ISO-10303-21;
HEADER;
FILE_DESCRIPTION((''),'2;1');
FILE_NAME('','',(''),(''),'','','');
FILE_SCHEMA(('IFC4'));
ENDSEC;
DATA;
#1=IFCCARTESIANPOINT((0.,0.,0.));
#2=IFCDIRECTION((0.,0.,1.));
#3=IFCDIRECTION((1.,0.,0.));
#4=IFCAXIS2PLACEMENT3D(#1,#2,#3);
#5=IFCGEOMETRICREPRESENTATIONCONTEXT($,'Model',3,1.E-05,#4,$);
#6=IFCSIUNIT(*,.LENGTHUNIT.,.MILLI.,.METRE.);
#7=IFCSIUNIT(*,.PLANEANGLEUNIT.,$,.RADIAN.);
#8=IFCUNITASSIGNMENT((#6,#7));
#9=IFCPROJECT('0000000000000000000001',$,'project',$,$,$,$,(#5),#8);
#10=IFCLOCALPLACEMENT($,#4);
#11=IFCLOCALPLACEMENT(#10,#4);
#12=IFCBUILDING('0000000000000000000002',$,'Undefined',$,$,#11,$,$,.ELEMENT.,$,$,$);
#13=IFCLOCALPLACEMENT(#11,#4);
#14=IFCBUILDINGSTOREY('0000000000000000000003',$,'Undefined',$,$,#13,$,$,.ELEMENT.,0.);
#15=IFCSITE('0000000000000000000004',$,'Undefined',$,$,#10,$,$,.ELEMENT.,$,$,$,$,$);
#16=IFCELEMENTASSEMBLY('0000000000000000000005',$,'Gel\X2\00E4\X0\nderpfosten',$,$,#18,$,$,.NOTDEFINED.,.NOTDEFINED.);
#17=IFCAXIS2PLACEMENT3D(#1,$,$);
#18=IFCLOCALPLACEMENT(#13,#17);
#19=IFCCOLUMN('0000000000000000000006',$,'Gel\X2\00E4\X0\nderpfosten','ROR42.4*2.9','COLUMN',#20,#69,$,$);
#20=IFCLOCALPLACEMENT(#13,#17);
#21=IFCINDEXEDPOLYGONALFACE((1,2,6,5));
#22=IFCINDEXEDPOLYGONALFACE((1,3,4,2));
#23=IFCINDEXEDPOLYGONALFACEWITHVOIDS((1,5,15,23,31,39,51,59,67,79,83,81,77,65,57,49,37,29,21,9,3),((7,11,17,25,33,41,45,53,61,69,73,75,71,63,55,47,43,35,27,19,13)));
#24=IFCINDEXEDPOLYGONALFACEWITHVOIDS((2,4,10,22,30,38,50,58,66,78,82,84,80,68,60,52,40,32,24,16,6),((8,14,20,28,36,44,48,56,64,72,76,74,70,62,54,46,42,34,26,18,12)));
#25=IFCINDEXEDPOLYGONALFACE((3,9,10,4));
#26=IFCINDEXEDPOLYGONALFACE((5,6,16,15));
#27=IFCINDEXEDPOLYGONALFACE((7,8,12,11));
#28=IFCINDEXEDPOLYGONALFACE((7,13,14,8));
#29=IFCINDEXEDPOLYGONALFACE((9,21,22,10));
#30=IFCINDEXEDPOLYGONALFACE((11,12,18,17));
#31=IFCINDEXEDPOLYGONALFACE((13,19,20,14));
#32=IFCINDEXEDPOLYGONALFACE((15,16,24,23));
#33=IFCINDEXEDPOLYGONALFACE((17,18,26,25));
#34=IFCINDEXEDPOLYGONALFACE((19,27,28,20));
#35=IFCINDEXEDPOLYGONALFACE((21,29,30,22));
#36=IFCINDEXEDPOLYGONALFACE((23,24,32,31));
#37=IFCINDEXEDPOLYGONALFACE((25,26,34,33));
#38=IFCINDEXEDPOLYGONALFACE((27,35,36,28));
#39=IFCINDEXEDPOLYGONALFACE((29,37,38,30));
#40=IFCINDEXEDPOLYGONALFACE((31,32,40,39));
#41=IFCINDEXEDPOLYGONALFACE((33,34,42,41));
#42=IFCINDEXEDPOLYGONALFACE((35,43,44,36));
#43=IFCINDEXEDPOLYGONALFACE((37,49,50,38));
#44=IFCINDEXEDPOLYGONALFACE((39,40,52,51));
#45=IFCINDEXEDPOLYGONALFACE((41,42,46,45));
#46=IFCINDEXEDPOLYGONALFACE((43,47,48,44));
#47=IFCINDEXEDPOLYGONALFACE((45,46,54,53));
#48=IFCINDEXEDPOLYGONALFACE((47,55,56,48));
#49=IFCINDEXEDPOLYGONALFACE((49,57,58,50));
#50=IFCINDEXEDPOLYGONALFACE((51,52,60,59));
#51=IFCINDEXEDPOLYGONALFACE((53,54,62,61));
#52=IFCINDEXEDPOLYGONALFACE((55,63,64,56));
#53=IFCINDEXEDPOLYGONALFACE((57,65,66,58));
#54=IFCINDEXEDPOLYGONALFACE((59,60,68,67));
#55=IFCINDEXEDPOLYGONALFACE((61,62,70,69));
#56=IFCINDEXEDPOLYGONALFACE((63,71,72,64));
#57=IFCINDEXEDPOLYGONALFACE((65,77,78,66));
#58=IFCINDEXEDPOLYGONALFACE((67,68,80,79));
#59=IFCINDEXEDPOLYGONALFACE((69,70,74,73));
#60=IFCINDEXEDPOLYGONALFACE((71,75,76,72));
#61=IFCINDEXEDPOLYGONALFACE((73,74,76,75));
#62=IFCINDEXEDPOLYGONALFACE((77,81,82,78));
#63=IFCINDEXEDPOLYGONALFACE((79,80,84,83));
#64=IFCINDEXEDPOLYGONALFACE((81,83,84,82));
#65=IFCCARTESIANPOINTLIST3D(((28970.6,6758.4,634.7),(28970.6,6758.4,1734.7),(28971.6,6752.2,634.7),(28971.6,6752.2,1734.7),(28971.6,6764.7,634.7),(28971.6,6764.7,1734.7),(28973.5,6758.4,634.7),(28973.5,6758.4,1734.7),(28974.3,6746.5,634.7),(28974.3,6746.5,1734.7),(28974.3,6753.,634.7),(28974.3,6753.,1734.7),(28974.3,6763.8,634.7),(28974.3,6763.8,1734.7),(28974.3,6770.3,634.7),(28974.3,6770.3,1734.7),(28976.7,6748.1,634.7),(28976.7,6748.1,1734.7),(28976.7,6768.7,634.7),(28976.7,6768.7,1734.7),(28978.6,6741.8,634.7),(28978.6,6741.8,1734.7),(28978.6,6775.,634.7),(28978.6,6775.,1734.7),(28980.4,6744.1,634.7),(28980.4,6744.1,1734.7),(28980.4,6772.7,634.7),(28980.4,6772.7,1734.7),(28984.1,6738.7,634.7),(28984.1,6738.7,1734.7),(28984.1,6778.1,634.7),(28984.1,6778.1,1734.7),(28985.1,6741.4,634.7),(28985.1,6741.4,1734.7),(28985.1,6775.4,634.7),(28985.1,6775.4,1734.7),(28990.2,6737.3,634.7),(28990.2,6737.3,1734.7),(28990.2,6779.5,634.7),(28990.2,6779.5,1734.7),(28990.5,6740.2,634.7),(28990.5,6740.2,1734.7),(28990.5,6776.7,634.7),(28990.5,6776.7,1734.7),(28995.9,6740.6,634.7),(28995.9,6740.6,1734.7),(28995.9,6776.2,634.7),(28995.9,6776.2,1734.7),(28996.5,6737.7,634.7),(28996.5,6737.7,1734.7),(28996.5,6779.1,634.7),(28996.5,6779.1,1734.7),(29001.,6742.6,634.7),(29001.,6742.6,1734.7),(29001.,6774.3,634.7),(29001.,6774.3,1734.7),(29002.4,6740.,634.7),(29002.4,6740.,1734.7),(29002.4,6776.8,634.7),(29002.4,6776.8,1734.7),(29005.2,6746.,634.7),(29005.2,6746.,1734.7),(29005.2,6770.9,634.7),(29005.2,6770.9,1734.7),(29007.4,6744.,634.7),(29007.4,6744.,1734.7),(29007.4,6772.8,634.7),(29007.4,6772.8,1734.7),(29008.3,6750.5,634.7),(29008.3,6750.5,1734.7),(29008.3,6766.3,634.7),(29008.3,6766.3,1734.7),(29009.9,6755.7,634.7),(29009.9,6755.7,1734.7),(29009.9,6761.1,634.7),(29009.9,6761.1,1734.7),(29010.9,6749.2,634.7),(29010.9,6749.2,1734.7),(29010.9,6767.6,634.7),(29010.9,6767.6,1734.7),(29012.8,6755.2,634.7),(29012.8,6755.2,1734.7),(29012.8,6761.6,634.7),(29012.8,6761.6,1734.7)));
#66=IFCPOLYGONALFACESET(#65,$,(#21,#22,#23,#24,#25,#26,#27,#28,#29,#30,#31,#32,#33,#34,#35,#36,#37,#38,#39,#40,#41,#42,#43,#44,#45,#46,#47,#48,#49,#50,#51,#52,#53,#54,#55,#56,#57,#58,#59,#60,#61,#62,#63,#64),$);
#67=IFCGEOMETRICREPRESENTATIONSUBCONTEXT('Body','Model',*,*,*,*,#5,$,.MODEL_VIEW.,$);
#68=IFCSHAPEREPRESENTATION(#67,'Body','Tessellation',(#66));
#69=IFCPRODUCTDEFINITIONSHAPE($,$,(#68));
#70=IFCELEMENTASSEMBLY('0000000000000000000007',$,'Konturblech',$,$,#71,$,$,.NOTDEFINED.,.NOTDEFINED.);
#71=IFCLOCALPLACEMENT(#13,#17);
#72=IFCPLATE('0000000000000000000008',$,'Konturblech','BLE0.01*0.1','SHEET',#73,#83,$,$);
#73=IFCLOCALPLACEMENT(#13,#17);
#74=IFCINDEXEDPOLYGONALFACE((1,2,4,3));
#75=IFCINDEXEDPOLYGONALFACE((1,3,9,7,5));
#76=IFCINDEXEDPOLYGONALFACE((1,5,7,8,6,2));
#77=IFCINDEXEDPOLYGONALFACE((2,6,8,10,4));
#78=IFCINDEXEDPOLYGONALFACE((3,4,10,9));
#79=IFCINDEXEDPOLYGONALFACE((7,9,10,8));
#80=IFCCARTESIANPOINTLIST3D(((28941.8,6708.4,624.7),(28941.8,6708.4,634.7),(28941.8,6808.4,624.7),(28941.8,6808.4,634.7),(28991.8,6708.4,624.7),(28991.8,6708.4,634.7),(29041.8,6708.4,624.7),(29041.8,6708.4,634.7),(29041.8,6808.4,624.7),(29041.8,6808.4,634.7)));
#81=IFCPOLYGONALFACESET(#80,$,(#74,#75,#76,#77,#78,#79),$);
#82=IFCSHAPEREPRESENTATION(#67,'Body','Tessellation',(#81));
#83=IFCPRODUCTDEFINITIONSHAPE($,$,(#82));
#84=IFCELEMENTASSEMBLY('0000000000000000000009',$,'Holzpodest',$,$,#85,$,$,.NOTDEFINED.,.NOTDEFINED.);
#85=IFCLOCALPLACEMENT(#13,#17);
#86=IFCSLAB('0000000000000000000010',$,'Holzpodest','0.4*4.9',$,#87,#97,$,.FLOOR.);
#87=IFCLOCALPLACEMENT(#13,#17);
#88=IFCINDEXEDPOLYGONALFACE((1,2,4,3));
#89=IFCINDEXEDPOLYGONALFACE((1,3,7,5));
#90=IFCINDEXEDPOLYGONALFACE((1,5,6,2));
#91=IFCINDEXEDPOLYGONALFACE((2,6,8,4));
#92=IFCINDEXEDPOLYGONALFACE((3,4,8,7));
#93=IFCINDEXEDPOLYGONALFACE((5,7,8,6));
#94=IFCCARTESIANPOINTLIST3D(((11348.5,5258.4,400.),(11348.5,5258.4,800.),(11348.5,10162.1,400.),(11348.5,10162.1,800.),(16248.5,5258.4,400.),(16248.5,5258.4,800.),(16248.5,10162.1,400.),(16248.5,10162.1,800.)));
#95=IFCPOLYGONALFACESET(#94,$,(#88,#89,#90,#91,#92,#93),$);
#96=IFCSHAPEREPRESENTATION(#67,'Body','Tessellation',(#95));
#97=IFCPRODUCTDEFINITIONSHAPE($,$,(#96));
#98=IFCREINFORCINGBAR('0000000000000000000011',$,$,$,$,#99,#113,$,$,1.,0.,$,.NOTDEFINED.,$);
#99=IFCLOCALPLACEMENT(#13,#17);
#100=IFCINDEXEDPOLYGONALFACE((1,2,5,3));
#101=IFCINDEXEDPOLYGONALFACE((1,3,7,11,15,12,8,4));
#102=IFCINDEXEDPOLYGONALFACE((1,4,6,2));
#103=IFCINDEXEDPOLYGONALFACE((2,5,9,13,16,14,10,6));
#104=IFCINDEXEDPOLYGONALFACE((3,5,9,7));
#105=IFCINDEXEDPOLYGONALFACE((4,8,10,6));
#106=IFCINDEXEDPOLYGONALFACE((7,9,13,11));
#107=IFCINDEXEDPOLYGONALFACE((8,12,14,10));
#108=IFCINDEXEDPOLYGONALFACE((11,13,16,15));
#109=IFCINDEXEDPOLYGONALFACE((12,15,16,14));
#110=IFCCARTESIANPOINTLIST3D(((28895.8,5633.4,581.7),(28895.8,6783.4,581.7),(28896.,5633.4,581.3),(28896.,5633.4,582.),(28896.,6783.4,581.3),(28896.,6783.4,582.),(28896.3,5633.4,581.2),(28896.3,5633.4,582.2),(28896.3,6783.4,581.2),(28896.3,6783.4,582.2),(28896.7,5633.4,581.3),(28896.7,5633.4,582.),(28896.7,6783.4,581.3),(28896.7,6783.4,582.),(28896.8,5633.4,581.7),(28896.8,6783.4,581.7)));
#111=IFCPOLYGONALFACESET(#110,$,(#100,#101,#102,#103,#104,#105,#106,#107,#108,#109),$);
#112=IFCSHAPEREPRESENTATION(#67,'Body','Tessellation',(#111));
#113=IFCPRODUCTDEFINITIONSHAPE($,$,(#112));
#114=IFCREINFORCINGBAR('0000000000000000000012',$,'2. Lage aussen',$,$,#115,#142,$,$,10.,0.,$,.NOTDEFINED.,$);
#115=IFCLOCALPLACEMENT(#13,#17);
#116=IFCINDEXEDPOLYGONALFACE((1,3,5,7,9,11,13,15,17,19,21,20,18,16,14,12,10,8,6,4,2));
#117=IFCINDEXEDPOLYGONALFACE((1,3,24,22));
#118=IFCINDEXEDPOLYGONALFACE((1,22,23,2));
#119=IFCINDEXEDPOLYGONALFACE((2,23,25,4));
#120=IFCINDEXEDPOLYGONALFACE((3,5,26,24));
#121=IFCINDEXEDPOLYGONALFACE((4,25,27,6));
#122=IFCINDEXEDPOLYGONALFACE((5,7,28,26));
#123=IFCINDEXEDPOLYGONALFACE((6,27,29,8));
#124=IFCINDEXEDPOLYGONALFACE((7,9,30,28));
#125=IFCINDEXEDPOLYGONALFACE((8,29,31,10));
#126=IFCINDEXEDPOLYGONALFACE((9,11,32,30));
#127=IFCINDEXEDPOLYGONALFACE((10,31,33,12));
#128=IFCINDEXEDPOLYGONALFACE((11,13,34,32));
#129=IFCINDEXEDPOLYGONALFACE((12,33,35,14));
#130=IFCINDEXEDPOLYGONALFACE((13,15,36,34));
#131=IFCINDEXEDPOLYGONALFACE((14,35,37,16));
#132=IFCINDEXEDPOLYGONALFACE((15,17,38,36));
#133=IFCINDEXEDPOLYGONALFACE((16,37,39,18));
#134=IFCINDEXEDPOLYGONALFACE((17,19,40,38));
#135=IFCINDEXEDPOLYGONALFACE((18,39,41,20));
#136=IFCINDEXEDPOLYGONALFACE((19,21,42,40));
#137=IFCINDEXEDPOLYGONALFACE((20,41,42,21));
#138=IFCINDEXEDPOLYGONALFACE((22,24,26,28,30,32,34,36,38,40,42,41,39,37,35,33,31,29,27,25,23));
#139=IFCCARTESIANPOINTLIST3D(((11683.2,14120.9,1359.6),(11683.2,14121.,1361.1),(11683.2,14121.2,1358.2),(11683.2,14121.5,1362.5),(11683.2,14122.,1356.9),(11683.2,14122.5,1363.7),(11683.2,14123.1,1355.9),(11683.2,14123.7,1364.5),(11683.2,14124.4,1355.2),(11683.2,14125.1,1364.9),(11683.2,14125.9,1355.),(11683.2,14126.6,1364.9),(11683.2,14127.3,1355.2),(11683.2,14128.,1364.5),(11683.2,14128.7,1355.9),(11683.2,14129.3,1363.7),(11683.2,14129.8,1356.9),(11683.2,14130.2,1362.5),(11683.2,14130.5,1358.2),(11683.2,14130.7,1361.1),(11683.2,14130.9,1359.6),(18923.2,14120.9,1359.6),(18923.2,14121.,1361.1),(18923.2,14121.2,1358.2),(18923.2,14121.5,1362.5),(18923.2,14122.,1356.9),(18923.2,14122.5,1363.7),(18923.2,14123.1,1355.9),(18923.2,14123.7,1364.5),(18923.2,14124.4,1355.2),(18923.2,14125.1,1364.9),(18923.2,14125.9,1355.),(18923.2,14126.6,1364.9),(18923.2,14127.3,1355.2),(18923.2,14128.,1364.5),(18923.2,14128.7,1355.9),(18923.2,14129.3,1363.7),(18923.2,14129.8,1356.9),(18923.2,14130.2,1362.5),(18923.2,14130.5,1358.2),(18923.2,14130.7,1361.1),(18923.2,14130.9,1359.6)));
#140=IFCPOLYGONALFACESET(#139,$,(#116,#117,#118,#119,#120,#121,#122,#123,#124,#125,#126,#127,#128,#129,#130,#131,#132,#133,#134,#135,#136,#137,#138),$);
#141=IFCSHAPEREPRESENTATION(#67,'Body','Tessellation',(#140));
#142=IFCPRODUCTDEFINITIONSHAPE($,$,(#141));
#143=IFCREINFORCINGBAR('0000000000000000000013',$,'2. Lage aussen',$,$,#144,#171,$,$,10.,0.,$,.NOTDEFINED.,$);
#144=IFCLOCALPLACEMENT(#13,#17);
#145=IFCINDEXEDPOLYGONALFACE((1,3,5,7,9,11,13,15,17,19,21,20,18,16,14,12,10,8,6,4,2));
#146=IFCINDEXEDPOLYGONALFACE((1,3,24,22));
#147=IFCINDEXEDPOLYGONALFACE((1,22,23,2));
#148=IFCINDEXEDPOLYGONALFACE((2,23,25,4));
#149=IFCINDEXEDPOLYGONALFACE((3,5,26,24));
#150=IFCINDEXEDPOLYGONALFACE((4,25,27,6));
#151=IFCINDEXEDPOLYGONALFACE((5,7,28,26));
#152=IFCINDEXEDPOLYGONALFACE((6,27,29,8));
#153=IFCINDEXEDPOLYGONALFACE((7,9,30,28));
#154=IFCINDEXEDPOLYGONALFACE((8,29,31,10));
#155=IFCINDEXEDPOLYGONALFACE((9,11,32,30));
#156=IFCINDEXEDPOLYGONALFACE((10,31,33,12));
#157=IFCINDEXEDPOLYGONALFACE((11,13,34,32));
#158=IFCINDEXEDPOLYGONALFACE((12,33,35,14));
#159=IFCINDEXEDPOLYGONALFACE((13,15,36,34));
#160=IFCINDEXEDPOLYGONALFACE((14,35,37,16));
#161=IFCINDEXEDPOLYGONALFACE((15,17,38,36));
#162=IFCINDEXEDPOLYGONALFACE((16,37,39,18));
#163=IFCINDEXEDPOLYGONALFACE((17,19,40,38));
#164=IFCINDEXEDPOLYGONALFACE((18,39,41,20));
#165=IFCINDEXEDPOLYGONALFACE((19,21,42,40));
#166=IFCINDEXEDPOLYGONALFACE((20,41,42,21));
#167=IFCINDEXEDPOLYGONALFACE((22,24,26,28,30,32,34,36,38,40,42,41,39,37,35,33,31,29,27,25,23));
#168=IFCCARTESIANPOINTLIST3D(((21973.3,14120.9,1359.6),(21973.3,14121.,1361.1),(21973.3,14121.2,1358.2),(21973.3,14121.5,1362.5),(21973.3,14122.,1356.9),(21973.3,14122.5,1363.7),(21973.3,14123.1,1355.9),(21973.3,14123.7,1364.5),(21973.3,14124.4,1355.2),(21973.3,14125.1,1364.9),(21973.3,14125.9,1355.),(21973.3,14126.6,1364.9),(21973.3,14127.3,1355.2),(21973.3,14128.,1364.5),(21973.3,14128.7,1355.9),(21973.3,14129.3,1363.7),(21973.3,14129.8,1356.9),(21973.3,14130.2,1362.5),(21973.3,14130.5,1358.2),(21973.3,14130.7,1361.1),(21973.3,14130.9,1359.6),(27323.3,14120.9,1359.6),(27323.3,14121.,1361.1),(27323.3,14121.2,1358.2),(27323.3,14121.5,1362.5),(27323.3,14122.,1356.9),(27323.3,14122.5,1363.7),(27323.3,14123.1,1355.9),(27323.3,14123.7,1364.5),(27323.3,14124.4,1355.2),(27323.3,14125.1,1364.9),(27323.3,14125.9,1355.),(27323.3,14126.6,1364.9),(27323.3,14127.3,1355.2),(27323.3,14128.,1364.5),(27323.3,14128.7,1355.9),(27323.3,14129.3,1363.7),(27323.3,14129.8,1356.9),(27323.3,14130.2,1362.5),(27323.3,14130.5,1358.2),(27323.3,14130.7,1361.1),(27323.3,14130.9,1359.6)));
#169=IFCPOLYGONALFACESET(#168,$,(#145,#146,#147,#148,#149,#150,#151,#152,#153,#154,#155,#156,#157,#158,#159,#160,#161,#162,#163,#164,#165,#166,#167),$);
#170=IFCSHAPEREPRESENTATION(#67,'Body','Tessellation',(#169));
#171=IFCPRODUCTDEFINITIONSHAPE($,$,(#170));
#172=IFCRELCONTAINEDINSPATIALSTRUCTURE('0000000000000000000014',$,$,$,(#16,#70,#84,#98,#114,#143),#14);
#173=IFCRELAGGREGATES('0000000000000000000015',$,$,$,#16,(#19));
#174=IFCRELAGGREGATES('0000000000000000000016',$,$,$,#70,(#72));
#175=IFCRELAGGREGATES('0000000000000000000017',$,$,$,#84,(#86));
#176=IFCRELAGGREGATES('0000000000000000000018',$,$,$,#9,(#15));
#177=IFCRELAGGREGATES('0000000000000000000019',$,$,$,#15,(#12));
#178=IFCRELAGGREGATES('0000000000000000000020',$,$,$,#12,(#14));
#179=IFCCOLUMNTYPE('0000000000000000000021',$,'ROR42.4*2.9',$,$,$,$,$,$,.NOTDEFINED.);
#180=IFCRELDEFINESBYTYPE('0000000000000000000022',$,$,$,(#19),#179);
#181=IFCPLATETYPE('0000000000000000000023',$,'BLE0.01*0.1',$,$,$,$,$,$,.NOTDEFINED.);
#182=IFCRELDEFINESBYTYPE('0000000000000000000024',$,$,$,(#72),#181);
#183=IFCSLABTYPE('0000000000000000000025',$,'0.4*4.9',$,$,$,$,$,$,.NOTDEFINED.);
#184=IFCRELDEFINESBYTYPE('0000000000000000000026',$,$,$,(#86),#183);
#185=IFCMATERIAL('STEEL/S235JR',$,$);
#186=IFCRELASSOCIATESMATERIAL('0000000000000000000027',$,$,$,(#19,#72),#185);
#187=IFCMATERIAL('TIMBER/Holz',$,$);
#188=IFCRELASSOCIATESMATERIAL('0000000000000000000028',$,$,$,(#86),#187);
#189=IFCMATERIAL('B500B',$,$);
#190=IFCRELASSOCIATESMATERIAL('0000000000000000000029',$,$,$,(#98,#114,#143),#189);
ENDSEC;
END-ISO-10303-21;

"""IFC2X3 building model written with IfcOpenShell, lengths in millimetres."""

from ifc_helpers import new_model, entity, si_unit, frame, origin_with_axes, origin_2d_with_axis, place, context, subcontext, project, spatial, polyline, hollow_circle, outline, extrude, source, transform, mapped, material, type_object, element, aggregate, save


model = new_model("IFC2X3")

# Units and contexts
model_context = context("Model", 3, precision=1e-05, world=origin_with_axes())
body_context = subcontext(model_context, "Body", "Model", "MODEL_VIEW")
ifc_project = project(units=[si_unit("LENGTHUNIT", "METRE", prefix="MILLI"), si_unit("PLANEANGLEUNIT", "RADIAN")], contexts=[model_context])

# Site, building, storey
site_placement = place(None, origin_with_axes())
site = spatial("IfcSite", under=ifc_project, at=site_placement, Name="Undefined", CompositionType="ELEMENT")
building_placement = place(site_placement, origin_with_axes())
building = spatial("IfcBuilding", under=site, at=building_placement, Name="Undefined", CompositionType="ELEMENT")
storey_placement = place(building_placement, origin_with_axes())
storey = spatial("IfcBuildingStorey", under=building, at=storey_placement, Name="Undefined", CompositionType="ELEMENT", Elevation=0.0)

# Element assembly, column
assembly_1_placement = place(storey_placement, origin_with_axes())
assembly_1 = element("IfcElementAssembly", 1, at=assembly_1_placement, inside=storey, Name="Geländerpfosten", AssemblyPlace="NOTDEFINED", PredefinedType="NOTDEFINED")
ifc_material_1 = material(Name="STEEL/S235JR")
column_type = type_object("IfcColumnType", Name="ROR42.4*2.9", PredefinedType="NOTDEFINED")
column_placement = place(assembly_1_placement, frame((28991.8, 6758.4, 634.7), z_axis=(0.0, 0.0, 1.0), x_axis=(0.0, 1.0, 0.0)))
column = element("IfcColumn", 2, at=column_placement, type_object=column_type, material=ifc_material_1, Name="Geländerpfosten", Description="ROR42.4*2.9", ObjectType="COLUMN", context=body_context, shape_type="SweptSolid", body=[
    extrude(hollow_circle(Radius=21.2, WallThickness=2.9, at=origin_2d_with_axis()), frame((0.0, 0.0, 1100.0), z_axis=(0.0, 0.0, -1.0), x_axis=(0.0, 1.0, 0.0)), (0.0, 0.0, 1.0), 1100.0),
])
aggregate(assembly_1, [column])

# Element assembly, plate
assembly_2_placement = place(storey_placement, origin_with_axes())
assembly_2 = element("IfcElementAssembly", 3, at=assembly_2_placement, inside=storey, Name="Konturblech", AssemblyPlace="NOTDEFINED", PredefinedType="NOTDEFINED")
plate_type = type_object("IfcPlateType", Name="BLE0.01*0.1", PredefinedType="NOTDEFINED")
plate_placement = place(assembly_2_placement, frame((28991.8, 6708.4, 629.7), z_axis=(0.0, 0.0, 1.0), x_axis=(1.0, 0.0, 0.0)))
plate = element("IfcPlate", 4, at=plate_placement, type_object=plate_type, material=ifc_material_1, Name="Konturblech", Description="BLE0.01*0.1", ObjectType="SHEET", context=body_context, shape_type="SweptSolid", body=[
    extrude(outline(polyline([(0.0, 0.0), (50.0, 0.0), (50.0, 100.0), (-50.0, 100.0), (-50.0, 0.0), (0.0, 0.0)])), frame((0.0, 0.0, -5.0), z_axis=(0.0, 0.0, 1.0), x_axis=(1.0, 0.0, 0.0)), (0.0, 0.0, 1.0), 10.0),
])
aggregate(assembly_2, [plate])

# Element assembly, slab
assembly_3_placement = place(storey_placement, origin_with_axes())
assembly_3 = element("IfcElementAssembly", 5, at=assembly_3_placement, inside=storey, Name="Holzpodest", AssemblyPlace="NOTDEFINED", PredefinedType="NOTDEFINED")
ifc_material_2 = material(Name="TIMBER/Holz")
slab_type = type_object("IfcSlabType", Name="0.4*4.9", PredefinedType="NOTDEFINED")
slab_placement = place(assembly_3_placement, frame((16248.5, 5258.4, 600.0), z_axis=(0.0, 0.0, 1.0), x_axis=(0.0, 1.0, 0.0)))
slab = element("IfcSlab", 6, at=slab_placement, type_object=slab_type, material=ifc_material_2, Name="Holzpodest", Description="0.4*4.9", PredefinedType="FLOOR", context=body_context, shape_type="SweptSolid", body=[
    extrude(outline(polyline([(0.0, 0.0), (4903.7, 0.0), (4903.8, 4900.0), (0.0, 4900.0), (0.0, 0.0)])), frame((0.0, 0.0, -200.0), z_axis=(0.0, 0.0, 1.0), x_axis=(1.0, 0.0, 0.0)), (0.0, 0.0, 1.0), 400.0),
])
aggregate(assembly_3, [slab])

# Reinforcing bars
ifc_material_3 = material(Name="B500B")
shared_shape_1 = source(origin_with_axes(), body_context, "Body", "AdvancedSweptSolid", [
    entity("IfcSweptDiskSolid", entity("IfcTrimmedCurve", entity("IfcLine", entity("IfcCartesianPoint", [0.0, 0.0, 0.0]), entity("IfcVector", entity("IfcDirection", [1.0, 0.0, 0.0]), 1.0)), [entity("IfcParameterValue", 0.0)], [entity("IfcParameterValue", 1150.0)], True, "PARAMETER"), 0.5, None, 0.0, 1150.0),
])
reinforcing_bar_1_placement = place(storey_placement, frame((28896.3, 6783.4, 581.7), z_axis=(0.0, 0.0, 1.0), x_axis=(0.0, -1.0, 0.0)))
element("IfcReinforcingBar", 7, at=reinforcing_bar_1_placement, inside=storey, material=ifc_material_3, BarRole="NOTDEFINED", CrossSectionArea=0.0, NominalDiameter=1.0, context=body_context, shape_type="MappedRepresentation", body=[
    mapped(shared_shape_1, transform((0.0, 0.0, 0.0))),
])
shared_shape_2 = source(origin_with_axes(), body_context, "Body", "AdvancedSweptSolid", [
    entity("IfcSweptDiskSolid", entity("IfcTrimmedCurve", entity("IfcLine", entity("IfcCartesianPoint", [0.0, 0.0, 0.0]), entity("IfcVector", entity("IfcDirection", [1.0, 0.0, 0.0]), 1.0)), [entity("IfcParameterValue", 0.0)], [entity("IfcParameterValue", 7240.0)], True, "PARAMETER"), 5.0, None, 0.0, 7240.0),
])
reinforcing_bar_2_placement = place(storey_placement, frame((11683.2, 14125.9, 1360.0), z_axis=(0.0, 0.0, -1.0), x_axis=(1.0, 0.0, 0.0)))
element("IfcReinforcingBar", 8, at=reinforcing_bar_2_placement, inside=storey, material=ifc_material_3, Name="2. Lage aussen", BarRole="NOTDEFINED", CrossSectionArea=0.0, NominalDiameter=10.0, context=body_context, shape_type="MappedRepresentation", body=[
    mapped(shared_shape_2, transform((0.0, 0.0, 0.0))),
])
shared_shape_3 = source(origin_with_axes(), body_context, "Body", "AdvancedSweptSolid", [
    entity("IfcSweptDiskSolid", entity("IfcTrimmedCurve", entity("IfcLine", entity("IfcCartesianPoint", [0.0, 0.0, 0.0]), entity("IfcVector", entity("IfcDirection", [1.0, 0.0, 0.0]), 1.0)), [entity("IfcParameterValue", 0.0)], [entity("IfcParameterValue", 5350.0)], True, "PARAMETER"), 5.0, None, 0.0, 5350.0),
])
reinforcing_bar_3_placement = place(storey_placement, frame((21973.3, 14125.9, 1360.0), z_axis=(0.0, 0.0, -1.0), x_axis=(1.0, 0.0, 0.0)))
element("IfcReinforcingBar", 9, at=reinforcing_bar_3_placement, inside=storey, material=ifc_material_3, Name="2. Lage aussen", BarRole="NOTDEFINED", CrossSectionArea=0.0, NominalDiameter=10.0, context=body_context, shape_type="MappedRepresentation", body=[
    mapped(shared_shape_3, transform((0.0, 0.0, 0.0))),
])

save(model, "model.ifc")
